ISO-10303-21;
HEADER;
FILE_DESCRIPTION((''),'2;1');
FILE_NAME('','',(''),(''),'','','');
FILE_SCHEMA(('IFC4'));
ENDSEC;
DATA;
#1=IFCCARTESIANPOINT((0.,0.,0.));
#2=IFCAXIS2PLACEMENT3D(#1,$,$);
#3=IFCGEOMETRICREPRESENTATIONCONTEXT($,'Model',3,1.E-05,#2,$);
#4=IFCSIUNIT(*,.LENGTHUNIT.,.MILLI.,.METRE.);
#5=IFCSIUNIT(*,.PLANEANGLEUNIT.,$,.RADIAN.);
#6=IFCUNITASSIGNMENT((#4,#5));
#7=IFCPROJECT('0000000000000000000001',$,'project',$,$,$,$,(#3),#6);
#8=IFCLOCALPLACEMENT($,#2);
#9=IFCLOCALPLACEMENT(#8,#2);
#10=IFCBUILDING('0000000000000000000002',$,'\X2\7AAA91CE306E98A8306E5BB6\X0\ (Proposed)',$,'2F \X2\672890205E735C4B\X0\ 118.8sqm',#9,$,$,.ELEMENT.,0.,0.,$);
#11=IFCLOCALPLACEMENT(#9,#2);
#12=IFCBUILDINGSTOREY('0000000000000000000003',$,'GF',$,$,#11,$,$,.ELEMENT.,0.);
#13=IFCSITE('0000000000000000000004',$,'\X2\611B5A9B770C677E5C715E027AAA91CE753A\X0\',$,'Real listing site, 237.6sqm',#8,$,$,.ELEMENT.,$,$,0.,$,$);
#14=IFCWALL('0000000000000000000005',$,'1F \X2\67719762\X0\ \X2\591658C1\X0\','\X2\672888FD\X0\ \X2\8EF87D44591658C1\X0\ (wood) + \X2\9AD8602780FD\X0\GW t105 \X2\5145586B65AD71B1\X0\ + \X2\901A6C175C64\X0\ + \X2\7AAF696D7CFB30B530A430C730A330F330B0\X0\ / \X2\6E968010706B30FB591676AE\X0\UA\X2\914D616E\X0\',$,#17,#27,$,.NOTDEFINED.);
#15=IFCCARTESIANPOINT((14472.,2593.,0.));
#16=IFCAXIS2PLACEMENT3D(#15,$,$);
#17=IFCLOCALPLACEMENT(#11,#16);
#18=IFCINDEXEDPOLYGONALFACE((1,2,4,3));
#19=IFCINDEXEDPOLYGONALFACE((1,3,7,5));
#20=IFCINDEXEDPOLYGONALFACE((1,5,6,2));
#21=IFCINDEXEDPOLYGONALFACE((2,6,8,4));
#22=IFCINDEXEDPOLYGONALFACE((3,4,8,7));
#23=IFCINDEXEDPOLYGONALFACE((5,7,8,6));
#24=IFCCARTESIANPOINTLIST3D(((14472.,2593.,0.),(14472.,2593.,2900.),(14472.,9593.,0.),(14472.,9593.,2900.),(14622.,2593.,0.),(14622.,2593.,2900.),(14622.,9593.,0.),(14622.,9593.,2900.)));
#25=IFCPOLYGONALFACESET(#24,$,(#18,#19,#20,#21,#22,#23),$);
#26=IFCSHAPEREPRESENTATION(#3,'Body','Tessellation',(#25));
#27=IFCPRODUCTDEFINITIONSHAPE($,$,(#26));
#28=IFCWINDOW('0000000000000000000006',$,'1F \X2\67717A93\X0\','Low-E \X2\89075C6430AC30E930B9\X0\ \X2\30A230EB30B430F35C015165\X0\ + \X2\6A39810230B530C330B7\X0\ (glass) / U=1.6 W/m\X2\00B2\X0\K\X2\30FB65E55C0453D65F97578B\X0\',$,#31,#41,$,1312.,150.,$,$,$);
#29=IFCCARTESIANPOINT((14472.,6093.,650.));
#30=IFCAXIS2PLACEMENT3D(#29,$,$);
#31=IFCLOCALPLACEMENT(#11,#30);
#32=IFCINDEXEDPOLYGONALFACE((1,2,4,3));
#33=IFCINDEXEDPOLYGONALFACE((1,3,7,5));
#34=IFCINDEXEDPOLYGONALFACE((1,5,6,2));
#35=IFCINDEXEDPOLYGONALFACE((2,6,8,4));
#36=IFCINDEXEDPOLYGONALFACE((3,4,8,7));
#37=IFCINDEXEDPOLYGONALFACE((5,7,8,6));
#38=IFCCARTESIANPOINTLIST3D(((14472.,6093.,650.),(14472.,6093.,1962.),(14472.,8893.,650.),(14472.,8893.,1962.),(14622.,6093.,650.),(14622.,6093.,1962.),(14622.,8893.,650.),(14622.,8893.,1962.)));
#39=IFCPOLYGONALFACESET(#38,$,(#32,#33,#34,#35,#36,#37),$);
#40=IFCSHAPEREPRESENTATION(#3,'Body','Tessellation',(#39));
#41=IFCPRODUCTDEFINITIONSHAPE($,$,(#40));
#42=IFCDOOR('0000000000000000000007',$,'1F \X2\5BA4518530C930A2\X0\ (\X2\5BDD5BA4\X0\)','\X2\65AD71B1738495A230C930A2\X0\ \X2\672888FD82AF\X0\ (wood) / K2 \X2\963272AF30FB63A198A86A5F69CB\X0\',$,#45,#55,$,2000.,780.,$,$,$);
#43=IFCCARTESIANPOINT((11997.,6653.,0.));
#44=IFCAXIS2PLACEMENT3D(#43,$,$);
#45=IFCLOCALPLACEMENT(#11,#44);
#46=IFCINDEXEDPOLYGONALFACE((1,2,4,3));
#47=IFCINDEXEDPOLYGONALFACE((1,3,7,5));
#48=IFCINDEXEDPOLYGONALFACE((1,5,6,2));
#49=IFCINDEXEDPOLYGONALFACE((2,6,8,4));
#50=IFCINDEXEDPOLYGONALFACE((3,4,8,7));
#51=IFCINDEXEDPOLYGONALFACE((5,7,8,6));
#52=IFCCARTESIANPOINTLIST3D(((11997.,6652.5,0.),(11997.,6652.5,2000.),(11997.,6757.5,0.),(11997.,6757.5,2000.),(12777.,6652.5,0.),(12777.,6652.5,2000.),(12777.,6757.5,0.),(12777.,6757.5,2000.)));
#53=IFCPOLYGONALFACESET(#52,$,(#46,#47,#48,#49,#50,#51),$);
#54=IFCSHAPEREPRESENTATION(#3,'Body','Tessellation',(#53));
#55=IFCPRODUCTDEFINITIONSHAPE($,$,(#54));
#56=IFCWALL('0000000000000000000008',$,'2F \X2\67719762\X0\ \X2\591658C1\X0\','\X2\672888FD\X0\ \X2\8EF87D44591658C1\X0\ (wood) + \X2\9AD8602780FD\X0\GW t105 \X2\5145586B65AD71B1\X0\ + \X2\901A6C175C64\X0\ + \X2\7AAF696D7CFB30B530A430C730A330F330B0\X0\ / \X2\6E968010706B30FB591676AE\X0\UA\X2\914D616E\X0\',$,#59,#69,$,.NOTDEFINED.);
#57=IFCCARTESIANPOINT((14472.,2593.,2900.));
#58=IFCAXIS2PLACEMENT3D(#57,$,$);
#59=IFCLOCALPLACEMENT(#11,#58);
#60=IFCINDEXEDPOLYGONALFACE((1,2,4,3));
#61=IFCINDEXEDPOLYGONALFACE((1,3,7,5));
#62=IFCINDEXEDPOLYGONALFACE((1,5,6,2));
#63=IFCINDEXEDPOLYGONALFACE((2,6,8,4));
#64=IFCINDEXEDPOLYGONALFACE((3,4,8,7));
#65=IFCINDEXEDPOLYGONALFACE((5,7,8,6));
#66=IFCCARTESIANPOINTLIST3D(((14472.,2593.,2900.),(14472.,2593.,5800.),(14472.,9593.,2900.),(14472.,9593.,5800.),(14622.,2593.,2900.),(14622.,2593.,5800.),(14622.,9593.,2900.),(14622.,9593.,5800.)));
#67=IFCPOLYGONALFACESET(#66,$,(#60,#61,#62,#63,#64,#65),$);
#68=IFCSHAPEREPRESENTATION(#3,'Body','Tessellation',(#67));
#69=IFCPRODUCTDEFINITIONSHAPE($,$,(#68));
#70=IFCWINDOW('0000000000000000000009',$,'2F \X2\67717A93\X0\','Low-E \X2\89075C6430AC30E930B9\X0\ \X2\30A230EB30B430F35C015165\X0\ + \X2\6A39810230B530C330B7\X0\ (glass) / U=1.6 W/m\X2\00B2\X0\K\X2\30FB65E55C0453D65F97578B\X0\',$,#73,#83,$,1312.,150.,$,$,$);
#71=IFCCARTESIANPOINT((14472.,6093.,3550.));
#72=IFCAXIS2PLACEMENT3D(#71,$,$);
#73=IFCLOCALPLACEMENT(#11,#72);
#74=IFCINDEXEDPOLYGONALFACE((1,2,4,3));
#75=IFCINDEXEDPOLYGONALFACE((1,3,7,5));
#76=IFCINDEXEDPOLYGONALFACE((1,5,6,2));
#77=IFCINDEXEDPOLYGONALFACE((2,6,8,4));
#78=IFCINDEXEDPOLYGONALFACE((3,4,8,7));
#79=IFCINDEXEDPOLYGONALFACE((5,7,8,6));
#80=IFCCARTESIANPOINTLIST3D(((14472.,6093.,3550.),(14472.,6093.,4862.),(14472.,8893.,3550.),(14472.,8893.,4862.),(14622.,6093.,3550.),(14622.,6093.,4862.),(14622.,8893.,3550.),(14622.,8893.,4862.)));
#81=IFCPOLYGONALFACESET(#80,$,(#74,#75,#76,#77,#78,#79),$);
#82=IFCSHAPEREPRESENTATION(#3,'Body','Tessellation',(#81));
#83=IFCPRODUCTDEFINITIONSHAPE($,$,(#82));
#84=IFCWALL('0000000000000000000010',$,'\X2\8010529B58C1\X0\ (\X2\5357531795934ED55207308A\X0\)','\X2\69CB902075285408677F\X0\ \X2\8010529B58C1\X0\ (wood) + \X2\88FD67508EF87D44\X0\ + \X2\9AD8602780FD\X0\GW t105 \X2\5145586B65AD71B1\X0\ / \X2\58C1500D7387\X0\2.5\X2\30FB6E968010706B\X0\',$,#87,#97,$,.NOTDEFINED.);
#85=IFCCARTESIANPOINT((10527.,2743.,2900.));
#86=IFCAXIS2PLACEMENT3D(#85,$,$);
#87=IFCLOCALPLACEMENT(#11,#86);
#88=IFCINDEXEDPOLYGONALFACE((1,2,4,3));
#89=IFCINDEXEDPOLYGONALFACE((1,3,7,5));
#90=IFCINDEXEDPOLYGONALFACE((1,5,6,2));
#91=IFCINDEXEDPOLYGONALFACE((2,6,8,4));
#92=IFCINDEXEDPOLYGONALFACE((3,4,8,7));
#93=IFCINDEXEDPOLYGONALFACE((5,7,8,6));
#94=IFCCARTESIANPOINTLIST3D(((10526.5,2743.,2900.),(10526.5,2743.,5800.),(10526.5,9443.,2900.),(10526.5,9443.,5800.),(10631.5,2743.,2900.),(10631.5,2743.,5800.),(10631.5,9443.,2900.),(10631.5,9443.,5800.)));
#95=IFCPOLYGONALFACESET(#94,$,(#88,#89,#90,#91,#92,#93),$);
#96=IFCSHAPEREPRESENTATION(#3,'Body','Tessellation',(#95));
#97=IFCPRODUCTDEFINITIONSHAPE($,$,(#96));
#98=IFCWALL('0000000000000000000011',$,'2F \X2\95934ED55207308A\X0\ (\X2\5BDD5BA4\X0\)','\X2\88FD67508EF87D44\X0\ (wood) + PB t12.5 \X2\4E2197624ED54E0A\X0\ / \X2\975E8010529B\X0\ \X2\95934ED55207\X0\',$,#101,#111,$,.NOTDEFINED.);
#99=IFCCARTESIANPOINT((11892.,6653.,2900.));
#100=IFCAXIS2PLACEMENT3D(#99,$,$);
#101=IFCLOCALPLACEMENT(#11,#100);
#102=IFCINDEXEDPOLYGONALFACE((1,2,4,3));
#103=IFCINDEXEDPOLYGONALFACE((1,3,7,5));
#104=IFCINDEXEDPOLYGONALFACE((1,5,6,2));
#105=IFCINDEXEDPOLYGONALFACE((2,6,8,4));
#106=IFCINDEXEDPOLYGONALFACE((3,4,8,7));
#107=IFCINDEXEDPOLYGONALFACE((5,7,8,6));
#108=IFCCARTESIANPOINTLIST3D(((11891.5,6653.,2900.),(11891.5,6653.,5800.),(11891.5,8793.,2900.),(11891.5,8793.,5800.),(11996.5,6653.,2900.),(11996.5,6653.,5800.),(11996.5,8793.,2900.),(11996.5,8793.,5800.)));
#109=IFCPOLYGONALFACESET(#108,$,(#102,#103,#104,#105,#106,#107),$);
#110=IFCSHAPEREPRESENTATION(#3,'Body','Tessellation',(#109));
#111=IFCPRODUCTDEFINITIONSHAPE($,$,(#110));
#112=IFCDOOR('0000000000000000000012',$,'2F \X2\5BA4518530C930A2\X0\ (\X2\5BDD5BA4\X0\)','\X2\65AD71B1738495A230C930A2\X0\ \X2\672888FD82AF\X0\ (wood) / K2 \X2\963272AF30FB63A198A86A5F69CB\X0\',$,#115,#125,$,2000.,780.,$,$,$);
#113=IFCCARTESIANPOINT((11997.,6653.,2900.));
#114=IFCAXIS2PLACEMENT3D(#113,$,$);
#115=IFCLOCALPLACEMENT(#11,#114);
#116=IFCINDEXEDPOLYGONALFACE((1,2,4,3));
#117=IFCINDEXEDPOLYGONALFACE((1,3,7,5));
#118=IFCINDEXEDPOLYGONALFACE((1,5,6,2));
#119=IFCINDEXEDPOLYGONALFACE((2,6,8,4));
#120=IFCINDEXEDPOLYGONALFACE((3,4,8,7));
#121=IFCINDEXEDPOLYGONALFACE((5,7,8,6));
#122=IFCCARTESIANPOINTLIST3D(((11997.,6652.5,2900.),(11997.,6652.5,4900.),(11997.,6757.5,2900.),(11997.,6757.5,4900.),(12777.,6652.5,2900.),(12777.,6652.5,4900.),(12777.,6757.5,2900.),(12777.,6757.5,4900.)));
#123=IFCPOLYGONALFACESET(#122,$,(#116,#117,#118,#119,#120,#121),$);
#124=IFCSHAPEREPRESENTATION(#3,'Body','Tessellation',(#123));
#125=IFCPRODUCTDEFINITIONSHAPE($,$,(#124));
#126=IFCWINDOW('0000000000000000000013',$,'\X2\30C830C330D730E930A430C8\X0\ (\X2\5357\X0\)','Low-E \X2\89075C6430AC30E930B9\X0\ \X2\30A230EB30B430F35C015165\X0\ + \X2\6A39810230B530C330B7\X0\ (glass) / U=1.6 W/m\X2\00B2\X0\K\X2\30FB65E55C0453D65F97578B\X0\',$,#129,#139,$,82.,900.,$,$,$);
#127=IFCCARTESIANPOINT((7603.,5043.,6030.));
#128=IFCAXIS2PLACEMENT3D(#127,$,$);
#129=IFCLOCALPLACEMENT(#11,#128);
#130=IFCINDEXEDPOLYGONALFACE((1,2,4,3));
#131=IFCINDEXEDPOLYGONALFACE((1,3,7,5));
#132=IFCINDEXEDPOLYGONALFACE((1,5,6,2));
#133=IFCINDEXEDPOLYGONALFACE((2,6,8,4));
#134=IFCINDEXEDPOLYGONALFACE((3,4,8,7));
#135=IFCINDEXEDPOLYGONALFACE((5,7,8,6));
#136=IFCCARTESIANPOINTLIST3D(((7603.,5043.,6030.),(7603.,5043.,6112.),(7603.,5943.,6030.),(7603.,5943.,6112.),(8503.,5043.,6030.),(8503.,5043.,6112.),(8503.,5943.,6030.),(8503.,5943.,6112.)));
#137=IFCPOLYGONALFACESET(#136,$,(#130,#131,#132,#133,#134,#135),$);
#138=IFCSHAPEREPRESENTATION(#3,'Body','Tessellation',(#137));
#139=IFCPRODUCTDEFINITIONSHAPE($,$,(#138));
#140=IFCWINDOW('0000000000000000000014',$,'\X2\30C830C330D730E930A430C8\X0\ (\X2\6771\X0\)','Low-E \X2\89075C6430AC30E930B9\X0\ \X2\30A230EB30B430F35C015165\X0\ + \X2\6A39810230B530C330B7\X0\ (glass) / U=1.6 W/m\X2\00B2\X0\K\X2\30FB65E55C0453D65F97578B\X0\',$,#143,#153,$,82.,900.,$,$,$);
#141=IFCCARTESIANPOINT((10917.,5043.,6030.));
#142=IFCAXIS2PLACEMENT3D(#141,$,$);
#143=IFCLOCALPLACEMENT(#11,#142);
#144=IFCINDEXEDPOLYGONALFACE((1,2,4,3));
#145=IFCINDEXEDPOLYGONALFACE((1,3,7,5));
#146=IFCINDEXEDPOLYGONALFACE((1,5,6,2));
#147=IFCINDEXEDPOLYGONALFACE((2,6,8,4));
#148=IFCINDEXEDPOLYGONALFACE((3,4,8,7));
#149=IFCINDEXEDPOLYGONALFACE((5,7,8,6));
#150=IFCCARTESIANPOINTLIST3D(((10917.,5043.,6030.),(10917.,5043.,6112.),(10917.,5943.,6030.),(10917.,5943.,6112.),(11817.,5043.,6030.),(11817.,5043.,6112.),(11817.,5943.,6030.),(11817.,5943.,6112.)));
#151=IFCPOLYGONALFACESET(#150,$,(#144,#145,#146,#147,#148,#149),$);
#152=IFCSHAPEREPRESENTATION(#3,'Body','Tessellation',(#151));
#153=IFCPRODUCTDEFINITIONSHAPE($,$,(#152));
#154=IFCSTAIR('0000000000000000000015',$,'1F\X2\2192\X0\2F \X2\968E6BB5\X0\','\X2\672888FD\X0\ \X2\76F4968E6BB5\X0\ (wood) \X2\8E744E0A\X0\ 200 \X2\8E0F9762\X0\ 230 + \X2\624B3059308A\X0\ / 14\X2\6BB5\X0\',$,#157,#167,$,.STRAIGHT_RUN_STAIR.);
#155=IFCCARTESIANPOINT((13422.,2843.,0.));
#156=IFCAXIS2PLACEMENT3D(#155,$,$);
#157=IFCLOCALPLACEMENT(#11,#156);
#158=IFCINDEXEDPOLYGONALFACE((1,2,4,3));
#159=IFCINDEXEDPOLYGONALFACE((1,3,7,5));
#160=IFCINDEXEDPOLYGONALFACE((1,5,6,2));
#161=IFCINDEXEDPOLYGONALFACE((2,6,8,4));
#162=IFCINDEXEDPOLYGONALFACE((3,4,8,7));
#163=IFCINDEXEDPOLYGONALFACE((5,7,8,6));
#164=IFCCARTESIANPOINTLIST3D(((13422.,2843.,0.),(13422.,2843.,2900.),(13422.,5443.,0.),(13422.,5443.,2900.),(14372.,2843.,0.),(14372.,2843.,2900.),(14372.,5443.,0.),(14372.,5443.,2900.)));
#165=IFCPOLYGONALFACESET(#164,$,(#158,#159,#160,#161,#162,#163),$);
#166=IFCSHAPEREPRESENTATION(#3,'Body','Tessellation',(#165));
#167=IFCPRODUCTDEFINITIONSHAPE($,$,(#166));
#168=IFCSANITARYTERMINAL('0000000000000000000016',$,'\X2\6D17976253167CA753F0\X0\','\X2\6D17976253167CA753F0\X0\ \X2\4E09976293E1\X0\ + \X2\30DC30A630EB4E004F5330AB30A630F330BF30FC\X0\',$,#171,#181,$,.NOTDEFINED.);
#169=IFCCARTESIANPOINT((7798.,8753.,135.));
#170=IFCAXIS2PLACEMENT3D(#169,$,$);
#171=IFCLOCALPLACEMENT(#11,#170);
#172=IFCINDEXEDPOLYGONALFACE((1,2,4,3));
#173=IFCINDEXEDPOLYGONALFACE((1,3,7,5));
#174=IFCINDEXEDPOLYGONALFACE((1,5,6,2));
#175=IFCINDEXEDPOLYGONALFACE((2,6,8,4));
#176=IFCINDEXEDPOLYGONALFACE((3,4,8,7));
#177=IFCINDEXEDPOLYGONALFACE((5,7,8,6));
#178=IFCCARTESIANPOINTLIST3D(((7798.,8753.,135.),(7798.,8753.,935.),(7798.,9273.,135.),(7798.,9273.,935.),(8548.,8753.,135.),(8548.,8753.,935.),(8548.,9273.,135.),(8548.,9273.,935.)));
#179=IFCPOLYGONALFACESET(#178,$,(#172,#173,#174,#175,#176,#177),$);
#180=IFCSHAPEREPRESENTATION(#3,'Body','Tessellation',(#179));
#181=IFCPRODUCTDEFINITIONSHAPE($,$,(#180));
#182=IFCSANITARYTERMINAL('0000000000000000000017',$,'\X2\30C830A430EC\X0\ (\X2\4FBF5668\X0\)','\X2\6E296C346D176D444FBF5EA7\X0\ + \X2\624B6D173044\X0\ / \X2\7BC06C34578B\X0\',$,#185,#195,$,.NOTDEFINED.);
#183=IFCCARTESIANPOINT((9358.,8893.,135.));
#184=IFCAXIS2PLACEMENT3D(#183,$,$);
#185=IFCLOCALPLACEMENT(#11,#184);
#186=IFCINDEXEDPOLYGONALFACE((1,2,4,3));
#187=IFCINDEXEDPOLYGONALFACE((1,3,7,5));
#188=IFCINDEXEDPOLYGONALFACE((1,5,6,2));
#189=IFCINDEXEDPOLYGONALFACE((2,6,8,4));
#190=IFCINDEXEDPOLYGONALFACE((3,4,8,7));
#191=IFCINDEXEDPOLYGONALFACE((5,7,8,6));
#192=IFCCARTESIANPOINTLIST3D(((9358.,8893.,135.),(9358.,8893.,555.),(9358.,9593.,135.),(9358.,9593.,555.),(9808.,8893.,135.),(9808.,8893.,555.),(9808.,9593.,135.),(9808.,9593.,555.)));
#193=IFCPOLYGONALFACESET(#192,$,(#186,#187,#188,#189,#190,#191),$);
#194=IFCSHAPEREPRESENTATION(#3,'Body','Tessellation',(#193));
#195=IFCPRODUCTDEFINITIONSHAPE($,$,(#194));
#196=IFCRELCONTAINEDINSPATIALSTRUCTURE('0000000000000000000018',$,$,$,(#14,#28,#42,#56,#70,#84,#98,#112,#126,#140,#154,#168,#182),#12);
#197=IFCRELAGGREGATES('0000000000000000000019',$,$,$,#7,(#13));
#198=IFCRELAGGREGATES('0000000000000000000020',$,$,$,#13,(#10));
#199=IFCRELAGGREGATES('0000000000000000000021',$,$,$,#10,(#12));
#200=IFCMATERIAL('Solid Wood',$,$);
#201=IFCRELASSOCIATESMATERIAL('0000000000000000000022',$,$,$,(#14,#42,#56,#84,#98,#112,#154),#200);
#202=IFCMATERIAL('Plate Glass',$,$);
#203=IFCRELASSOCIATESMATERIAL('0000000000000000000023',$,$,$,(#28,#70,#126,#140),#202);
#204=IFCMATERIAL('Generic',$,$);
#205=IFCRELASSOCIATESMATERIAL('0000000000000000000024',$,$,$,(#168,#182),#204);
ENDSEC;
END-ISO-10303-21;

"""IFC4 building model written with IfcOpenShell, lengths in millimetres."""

from ifc_helpers import new_model, si_unit, frame, frame_2d, origin, place, context, project, spatial, rectangle, extrude, material, element, fill, save


model = new_model("IFC4")

# Units and contexts
model_context = context("Model", 3, precision=1e-05, world=origin())
ifc_project = project(units=[si_unit("LENGTHUNIT", "METRE", prefix="MILLI"), si_unit("PLANEANGLEUNIT", "RADIAN")], contexts=[model_context])

# Site, building, storey
site_placement = place(None, origin())
site = spatial("IfcSite", under=ifc_project, at=site_placement, Name="愛媛県松山市窪野町", ObjectType="Real listing site, 237.6sqm", CompositionType="ELEMENT", RefElevation=0.0)
building_placement = place(site_placement, origin())
building = spatial("IfcBuilding", under=site, at=building_placement, Name="窪野の風の家 (Proposed)", ObjectType="2F 木造平屋 118.8sqm", CompositionType="ELEMENT", ElevationOfRefHeight=0.0, ElevationOfTerrain=0.0)
storey_placement = place(building_placement, origin())
storey = spatial("IfcBuildingStorey", under=building, at=storey_placement, Name="GF", CompositionType="ELEMENT", Elevation=0.0)

# Wall, opening, window
ifc_material_1 = material(Name="Solid Wood")
wall_1_placement = place(storey_placement, frame((14472.0, 2593.0, 0.0)))
wall_1 = element("IfcWall", 1, at=wall_1_placement, inside=storey, material=ifc_material_1, Name="1F 東面 外壁", Description="木製 軸組外壁 (wood) + 高性能GW t105 充填断熱 + 通気層 + 窯業系サイディング / 準耐火・外皮UA配慮", PredefinedType="NOTDEFINED", context=model_context, shape_type="SweptSolid", body=[
    extrude(rectangle(XDim=150.0, YDim=7000.0, at=frame_2d((75.0, 3500.0))), frame((14472.0, 2593.0, 0.0)), (0.0, 0.0, 1.0), 2900.0),
])
opening_1_placement = place(storey_placement, frame((14472.0, 6093.0, 650.0)))
opening_1 = element("IfcOpeningElement", 2, at=opening_1_placement, cuts=wall_1, PredefinedType="NOTDEFINED", context=model_context, shape_type="SweptSolid", body=[
    extrude(rectangle(XDim=150.0, YDim=2800.0, at=frame_2d((75.0, 1400.0))), frame((14472.0, 6093.0, 650.0)), (0.0, 0.0, 1.0), 1312.0),
])
ifc_material_2 = material(Name="Plate Glass")
window_1_placement = place(storey_placement, frame((14472.0, 6093.0, 650.0)))
window_1 = element("IfcWindow", 3, at=window_1_placement, inside=storey, material=ifc_material_2, Name="1F 東窓", Description="Low-E 複層ガラス アルゴン封入 + 樹脂サッシ (glass) / U=1.6 W/m²K・日射取得型", OverallHeight=1312.0, OverallWidth=150.0, context=model_context, shape_type="SweptSolid", body=[
    extrude(rectangle(XDim=150.0, YDim=2800.0, at=frame_2d((75.0, 1400.0))), frame((14472.0, 6093.0, 650.0)), (0.0, 0.0, 1.0), 1312.0),
])
fill(opening_1, window_1)

# Door
door_1_placement = place(storey_placement, frame((11997.0, 6653.0, 0.0)))
element("IfcDoor", 4, at=door_1_placement, inside=storey, material=ifc_material_1, Name="1F 室内ドア (寝室)", Description="断熱玄関ドア 木製芯 (wood) / K2 防犯・採風機構", OverallHeight=2000.0, OverallWidth=780.0, context=model_context, shape_type="SweptSolid", body=[
    extrude(rectangle(XDim=780.0, YDim=105.0, at=frame_2d((390.0, 52.0))), frame((11997.0, 6653.0, 0.0)), (0.0, 0.0, 1.0), 2000.0),
])

# Wall, opening, window
wall_2_placement = place(storey_placement, frame((14472.0, 2593.0, 2900.0)))
wall_2 = element("IfcWall", 5, at=wall_2_placement, inside=storey, material=ifc_material_1, Name="2F 東面 外壁", Description="木製 軸組外壁 (wood) + 高性能GW t105 充填断熱 + 通気層 + 窯業系サイディング / 準耐火・外皮UA配慮", PredefinedType="NOTDEFINED", context=model_context, shape_type="SweptSolid", body=[
    extrude(rectangle(XDim=150.0, YDim=7000.0, at=frame_2d((75.0, 3500.0))), frame((14472.0, 2593.0, 2900.0)), (0.0, 0.0, 1.0), 2900.0),
])
opening_2_placement = place(storey_placement, frame((14472.0, 6093.0, 3550.0)))
opening_2 = element("IfcOpeningElement", 6, at=opening_2_placement, cuts=wall_2, PredefinedType="NOTDEFINED", context=model_context, shape_type="SweptSolid", body=[
    extrude(rectangle(XDim=150.0, YDim=2800.0, at=frame_2d((75.0, 1400.0))), frame((14472.0, 6093.0, 3550.0)), (0.0, 0.0, 1.0), 1312.0),
])
window_2_placement = place(storey_placement, frame((14472.0, 6093.0, 3550.0)))
window_2 = element("IfcWindow", 7, at=window_2_placement, inside=storey, material=ifc_material_2, Name="2F 東窓", Description="Low-E 複層ガラス アルゴン封入 + 樹脂サッシ (glass) / U=1.6 W/m²K・日射取得型", OverallHeight=1312.0, OverallWidth=150.0, context=model_context, shape_type="SweptSolid", body=[
    extrude(rectangle(XDim=150.0, YDim=2800.0, at=frame_2d((75.0, 1400.0))), frame((14472.0, 6093.0, 3550.0)), (0.0, 0.0, 1.0), 1312.0),
])
fill(opening_2, window_2)

# Walls
wall_3_placement = place(storey_placement, frame((10527.0, 2743.0, 2900.0)))
element("IfcWall", 8, at=wall_3_placement, inside=storey, material=ifc_material_1, Name="耐力壁 (南北間仕切り)", Description="構造用合板 耐力壁 (wood) + 製材軸組 + 高性能GW t105 充填断熱 / 壁倍率2.5・準耐火", PredefinedType="NOTDEFINED", context=model_context, shape_type="SweptSolid", body=[
    extrude(rectangle(XDim=105.0, YDim=6700.0, at=frame_2d((52.0, 3350.0))), frame((10527.0, 2743.0, 2900.0)), (0.0, 0.0, 1.0), 2900.0),
])
wall_4_placement = place(storey_placement, frame((11892.0, 6653.0, 2900.0)))
element("IfcWall", 9, at=wall_4_placement, inside=storey, material=ifc_material_1, Name="2F 間仕切り (寝室)", Description="製材軸組 (wood) + PB t12.5 両面仕上 / 非耐力 間仕切", PredefinedType="NOTDEFINED", context=model_context, shape_type="SweptSolid", body=[
    extrude(rectangle(XDim=105.0, YDim=2140.0, at=frame_2d((52.0, 1070.0))), frame((11892.0, 6653.0, 2900.0)), (0.0, 0.0, 1.0), 2900.0),
])

# Door
door_2_placement = place(storey_placement, frame((11997.0, 6653.0, 2900.0)))
element("IfcDoor", 10, at=door_2_placement, inside=storey, material=ifc_material_1, Name="2F 室内ドア (寝室)", Description="断熱玄関ドア 木製芯 (wood) / K2 防犯・採風機構", OverallHeight=2000.0, OverallWidth=780.0, context=model_context, shape_type="SweptSolid", body=[
    extrude(rectangle(XDim=780.0, YDim=105.0, at=frame_2d((390.0, 52.0))), frame((11997.0, 6653.0, 2900.0)), (0.0, 0.0, 1.0), 2000.0),
])

# Windows
window_3_placement = place(storey_placement, frame((7603.0, 5043.0, 6030.0)))
element("IfcWindow", 11, at=window_3_placement, inside=storey, material=ifc_material_2, Name="トップライト (南)", Description="Low-E 複層ガラス アルゴン封入 + 樹脂サッシ (glass) / U=1.6 W/m²K・日射取得型", OverallHeight=82.0, OverallWidth=900.0, context=model_context, shape_type="SweptSolid", body=[
    extrude(rectangle(XDim=900.0, YDim=900.0, at=frame_2d((450.0, 450.0))), frame((7603.0, 5043.0, 6030.0)), (0.0, 0.0, 1.0), 82.0),
])
window_4_placement = place(storey_placement, frame((10917.0, 5043.0, 6030.0)))
element("IfcWindow", 12, at=window_4_placement, inside=storey, material=ifc_material_2, Name="トップライト (東)", Description="Low-E 複層ガラス アルゴン封入 + 樹脂サッシ (glass) / U=1.6 W/m²K・日射取得型", OverallHeight=82.0, OverallWidth=900.0, context=model_context, shape_type="SweptSolid", body=[
    extrude(rectangle(XDim=900.0, YDim=900.0, at=frame_2d((450.0, 450.0))), frame((10917.0, 5043.0, 6030.0)), (0.0, 0.0, 1.0), 82.0),
])

# Stair
stair_placement = place(storey_placement, frame((13422.0, 2843.0, 0.0)))
element("IfcStair", 13, at=stair_placement, inside=storey, material=ifc_material_1, Name="1F→2F 階段", Description="木製 直階段 (wood) 蹴上 200 踏面 230 + 手すり / 14段", PredefinedType="STRAIGHT_RUN_STAIR", context=model_context, shape_type="SweptSolid", body=[
    extrude(rectangle(XDim=950.0, YDim=2600.0, at=frame_2d((475.0, 1300.0))), frame((13422.0, 2843.0, 0.0)), (0.0, 0.0, 1.0), 2900.0),
])

# Sanitary terminals
ifc_material_3 = material(Name="Generic")
sanitary_terminal_1_placement = place(storey_placement, frame((7798.0, 8753.0, 135.0)))
element("IfcSanitaryTerminal", 14, at=sanitary_terminal_1_placement, inside=storey, material=ifc_material_3, Name="洗面化粧台", Description="洗面化粧台 三面鏡 + ボウル一体カウンター", PredefinedType="NOTDEFINED", context=model_context, shape_type="SweptSolid", body=[
    extrude(rectangle(XDim=750.0, YDim=520.0, at=frame_2d((375.0, 260.0))), frame((7798.0, 8753.0, 135.0)), (0.0, 0.0, 1.0), 800.0),
])
sanitary_terminal_2_placement = place(storey_placement, frame((9358.0, 8893.0, 135.0)))
element("IfcSanitaryTerminal", 15, at=sanitary_terminal_2_placement, inside=storey, material=ifc_material_3, Name="トイレ (便器)", Description="温水洗浄便座 + 手洗い / 節水型", PredefinedType="NOTDEFINED", context=model_context, shape_type="SweptSolid", body=[
    extrude(rectangle(XDim=450.0, YDim=700.0, at=frame_2d((225.0, 350.0))), frame((9358.0, 8893.0, 135.0)), (0.0, 0.0, 1.0), 420.0),
])

save(model, "model.ifc")
